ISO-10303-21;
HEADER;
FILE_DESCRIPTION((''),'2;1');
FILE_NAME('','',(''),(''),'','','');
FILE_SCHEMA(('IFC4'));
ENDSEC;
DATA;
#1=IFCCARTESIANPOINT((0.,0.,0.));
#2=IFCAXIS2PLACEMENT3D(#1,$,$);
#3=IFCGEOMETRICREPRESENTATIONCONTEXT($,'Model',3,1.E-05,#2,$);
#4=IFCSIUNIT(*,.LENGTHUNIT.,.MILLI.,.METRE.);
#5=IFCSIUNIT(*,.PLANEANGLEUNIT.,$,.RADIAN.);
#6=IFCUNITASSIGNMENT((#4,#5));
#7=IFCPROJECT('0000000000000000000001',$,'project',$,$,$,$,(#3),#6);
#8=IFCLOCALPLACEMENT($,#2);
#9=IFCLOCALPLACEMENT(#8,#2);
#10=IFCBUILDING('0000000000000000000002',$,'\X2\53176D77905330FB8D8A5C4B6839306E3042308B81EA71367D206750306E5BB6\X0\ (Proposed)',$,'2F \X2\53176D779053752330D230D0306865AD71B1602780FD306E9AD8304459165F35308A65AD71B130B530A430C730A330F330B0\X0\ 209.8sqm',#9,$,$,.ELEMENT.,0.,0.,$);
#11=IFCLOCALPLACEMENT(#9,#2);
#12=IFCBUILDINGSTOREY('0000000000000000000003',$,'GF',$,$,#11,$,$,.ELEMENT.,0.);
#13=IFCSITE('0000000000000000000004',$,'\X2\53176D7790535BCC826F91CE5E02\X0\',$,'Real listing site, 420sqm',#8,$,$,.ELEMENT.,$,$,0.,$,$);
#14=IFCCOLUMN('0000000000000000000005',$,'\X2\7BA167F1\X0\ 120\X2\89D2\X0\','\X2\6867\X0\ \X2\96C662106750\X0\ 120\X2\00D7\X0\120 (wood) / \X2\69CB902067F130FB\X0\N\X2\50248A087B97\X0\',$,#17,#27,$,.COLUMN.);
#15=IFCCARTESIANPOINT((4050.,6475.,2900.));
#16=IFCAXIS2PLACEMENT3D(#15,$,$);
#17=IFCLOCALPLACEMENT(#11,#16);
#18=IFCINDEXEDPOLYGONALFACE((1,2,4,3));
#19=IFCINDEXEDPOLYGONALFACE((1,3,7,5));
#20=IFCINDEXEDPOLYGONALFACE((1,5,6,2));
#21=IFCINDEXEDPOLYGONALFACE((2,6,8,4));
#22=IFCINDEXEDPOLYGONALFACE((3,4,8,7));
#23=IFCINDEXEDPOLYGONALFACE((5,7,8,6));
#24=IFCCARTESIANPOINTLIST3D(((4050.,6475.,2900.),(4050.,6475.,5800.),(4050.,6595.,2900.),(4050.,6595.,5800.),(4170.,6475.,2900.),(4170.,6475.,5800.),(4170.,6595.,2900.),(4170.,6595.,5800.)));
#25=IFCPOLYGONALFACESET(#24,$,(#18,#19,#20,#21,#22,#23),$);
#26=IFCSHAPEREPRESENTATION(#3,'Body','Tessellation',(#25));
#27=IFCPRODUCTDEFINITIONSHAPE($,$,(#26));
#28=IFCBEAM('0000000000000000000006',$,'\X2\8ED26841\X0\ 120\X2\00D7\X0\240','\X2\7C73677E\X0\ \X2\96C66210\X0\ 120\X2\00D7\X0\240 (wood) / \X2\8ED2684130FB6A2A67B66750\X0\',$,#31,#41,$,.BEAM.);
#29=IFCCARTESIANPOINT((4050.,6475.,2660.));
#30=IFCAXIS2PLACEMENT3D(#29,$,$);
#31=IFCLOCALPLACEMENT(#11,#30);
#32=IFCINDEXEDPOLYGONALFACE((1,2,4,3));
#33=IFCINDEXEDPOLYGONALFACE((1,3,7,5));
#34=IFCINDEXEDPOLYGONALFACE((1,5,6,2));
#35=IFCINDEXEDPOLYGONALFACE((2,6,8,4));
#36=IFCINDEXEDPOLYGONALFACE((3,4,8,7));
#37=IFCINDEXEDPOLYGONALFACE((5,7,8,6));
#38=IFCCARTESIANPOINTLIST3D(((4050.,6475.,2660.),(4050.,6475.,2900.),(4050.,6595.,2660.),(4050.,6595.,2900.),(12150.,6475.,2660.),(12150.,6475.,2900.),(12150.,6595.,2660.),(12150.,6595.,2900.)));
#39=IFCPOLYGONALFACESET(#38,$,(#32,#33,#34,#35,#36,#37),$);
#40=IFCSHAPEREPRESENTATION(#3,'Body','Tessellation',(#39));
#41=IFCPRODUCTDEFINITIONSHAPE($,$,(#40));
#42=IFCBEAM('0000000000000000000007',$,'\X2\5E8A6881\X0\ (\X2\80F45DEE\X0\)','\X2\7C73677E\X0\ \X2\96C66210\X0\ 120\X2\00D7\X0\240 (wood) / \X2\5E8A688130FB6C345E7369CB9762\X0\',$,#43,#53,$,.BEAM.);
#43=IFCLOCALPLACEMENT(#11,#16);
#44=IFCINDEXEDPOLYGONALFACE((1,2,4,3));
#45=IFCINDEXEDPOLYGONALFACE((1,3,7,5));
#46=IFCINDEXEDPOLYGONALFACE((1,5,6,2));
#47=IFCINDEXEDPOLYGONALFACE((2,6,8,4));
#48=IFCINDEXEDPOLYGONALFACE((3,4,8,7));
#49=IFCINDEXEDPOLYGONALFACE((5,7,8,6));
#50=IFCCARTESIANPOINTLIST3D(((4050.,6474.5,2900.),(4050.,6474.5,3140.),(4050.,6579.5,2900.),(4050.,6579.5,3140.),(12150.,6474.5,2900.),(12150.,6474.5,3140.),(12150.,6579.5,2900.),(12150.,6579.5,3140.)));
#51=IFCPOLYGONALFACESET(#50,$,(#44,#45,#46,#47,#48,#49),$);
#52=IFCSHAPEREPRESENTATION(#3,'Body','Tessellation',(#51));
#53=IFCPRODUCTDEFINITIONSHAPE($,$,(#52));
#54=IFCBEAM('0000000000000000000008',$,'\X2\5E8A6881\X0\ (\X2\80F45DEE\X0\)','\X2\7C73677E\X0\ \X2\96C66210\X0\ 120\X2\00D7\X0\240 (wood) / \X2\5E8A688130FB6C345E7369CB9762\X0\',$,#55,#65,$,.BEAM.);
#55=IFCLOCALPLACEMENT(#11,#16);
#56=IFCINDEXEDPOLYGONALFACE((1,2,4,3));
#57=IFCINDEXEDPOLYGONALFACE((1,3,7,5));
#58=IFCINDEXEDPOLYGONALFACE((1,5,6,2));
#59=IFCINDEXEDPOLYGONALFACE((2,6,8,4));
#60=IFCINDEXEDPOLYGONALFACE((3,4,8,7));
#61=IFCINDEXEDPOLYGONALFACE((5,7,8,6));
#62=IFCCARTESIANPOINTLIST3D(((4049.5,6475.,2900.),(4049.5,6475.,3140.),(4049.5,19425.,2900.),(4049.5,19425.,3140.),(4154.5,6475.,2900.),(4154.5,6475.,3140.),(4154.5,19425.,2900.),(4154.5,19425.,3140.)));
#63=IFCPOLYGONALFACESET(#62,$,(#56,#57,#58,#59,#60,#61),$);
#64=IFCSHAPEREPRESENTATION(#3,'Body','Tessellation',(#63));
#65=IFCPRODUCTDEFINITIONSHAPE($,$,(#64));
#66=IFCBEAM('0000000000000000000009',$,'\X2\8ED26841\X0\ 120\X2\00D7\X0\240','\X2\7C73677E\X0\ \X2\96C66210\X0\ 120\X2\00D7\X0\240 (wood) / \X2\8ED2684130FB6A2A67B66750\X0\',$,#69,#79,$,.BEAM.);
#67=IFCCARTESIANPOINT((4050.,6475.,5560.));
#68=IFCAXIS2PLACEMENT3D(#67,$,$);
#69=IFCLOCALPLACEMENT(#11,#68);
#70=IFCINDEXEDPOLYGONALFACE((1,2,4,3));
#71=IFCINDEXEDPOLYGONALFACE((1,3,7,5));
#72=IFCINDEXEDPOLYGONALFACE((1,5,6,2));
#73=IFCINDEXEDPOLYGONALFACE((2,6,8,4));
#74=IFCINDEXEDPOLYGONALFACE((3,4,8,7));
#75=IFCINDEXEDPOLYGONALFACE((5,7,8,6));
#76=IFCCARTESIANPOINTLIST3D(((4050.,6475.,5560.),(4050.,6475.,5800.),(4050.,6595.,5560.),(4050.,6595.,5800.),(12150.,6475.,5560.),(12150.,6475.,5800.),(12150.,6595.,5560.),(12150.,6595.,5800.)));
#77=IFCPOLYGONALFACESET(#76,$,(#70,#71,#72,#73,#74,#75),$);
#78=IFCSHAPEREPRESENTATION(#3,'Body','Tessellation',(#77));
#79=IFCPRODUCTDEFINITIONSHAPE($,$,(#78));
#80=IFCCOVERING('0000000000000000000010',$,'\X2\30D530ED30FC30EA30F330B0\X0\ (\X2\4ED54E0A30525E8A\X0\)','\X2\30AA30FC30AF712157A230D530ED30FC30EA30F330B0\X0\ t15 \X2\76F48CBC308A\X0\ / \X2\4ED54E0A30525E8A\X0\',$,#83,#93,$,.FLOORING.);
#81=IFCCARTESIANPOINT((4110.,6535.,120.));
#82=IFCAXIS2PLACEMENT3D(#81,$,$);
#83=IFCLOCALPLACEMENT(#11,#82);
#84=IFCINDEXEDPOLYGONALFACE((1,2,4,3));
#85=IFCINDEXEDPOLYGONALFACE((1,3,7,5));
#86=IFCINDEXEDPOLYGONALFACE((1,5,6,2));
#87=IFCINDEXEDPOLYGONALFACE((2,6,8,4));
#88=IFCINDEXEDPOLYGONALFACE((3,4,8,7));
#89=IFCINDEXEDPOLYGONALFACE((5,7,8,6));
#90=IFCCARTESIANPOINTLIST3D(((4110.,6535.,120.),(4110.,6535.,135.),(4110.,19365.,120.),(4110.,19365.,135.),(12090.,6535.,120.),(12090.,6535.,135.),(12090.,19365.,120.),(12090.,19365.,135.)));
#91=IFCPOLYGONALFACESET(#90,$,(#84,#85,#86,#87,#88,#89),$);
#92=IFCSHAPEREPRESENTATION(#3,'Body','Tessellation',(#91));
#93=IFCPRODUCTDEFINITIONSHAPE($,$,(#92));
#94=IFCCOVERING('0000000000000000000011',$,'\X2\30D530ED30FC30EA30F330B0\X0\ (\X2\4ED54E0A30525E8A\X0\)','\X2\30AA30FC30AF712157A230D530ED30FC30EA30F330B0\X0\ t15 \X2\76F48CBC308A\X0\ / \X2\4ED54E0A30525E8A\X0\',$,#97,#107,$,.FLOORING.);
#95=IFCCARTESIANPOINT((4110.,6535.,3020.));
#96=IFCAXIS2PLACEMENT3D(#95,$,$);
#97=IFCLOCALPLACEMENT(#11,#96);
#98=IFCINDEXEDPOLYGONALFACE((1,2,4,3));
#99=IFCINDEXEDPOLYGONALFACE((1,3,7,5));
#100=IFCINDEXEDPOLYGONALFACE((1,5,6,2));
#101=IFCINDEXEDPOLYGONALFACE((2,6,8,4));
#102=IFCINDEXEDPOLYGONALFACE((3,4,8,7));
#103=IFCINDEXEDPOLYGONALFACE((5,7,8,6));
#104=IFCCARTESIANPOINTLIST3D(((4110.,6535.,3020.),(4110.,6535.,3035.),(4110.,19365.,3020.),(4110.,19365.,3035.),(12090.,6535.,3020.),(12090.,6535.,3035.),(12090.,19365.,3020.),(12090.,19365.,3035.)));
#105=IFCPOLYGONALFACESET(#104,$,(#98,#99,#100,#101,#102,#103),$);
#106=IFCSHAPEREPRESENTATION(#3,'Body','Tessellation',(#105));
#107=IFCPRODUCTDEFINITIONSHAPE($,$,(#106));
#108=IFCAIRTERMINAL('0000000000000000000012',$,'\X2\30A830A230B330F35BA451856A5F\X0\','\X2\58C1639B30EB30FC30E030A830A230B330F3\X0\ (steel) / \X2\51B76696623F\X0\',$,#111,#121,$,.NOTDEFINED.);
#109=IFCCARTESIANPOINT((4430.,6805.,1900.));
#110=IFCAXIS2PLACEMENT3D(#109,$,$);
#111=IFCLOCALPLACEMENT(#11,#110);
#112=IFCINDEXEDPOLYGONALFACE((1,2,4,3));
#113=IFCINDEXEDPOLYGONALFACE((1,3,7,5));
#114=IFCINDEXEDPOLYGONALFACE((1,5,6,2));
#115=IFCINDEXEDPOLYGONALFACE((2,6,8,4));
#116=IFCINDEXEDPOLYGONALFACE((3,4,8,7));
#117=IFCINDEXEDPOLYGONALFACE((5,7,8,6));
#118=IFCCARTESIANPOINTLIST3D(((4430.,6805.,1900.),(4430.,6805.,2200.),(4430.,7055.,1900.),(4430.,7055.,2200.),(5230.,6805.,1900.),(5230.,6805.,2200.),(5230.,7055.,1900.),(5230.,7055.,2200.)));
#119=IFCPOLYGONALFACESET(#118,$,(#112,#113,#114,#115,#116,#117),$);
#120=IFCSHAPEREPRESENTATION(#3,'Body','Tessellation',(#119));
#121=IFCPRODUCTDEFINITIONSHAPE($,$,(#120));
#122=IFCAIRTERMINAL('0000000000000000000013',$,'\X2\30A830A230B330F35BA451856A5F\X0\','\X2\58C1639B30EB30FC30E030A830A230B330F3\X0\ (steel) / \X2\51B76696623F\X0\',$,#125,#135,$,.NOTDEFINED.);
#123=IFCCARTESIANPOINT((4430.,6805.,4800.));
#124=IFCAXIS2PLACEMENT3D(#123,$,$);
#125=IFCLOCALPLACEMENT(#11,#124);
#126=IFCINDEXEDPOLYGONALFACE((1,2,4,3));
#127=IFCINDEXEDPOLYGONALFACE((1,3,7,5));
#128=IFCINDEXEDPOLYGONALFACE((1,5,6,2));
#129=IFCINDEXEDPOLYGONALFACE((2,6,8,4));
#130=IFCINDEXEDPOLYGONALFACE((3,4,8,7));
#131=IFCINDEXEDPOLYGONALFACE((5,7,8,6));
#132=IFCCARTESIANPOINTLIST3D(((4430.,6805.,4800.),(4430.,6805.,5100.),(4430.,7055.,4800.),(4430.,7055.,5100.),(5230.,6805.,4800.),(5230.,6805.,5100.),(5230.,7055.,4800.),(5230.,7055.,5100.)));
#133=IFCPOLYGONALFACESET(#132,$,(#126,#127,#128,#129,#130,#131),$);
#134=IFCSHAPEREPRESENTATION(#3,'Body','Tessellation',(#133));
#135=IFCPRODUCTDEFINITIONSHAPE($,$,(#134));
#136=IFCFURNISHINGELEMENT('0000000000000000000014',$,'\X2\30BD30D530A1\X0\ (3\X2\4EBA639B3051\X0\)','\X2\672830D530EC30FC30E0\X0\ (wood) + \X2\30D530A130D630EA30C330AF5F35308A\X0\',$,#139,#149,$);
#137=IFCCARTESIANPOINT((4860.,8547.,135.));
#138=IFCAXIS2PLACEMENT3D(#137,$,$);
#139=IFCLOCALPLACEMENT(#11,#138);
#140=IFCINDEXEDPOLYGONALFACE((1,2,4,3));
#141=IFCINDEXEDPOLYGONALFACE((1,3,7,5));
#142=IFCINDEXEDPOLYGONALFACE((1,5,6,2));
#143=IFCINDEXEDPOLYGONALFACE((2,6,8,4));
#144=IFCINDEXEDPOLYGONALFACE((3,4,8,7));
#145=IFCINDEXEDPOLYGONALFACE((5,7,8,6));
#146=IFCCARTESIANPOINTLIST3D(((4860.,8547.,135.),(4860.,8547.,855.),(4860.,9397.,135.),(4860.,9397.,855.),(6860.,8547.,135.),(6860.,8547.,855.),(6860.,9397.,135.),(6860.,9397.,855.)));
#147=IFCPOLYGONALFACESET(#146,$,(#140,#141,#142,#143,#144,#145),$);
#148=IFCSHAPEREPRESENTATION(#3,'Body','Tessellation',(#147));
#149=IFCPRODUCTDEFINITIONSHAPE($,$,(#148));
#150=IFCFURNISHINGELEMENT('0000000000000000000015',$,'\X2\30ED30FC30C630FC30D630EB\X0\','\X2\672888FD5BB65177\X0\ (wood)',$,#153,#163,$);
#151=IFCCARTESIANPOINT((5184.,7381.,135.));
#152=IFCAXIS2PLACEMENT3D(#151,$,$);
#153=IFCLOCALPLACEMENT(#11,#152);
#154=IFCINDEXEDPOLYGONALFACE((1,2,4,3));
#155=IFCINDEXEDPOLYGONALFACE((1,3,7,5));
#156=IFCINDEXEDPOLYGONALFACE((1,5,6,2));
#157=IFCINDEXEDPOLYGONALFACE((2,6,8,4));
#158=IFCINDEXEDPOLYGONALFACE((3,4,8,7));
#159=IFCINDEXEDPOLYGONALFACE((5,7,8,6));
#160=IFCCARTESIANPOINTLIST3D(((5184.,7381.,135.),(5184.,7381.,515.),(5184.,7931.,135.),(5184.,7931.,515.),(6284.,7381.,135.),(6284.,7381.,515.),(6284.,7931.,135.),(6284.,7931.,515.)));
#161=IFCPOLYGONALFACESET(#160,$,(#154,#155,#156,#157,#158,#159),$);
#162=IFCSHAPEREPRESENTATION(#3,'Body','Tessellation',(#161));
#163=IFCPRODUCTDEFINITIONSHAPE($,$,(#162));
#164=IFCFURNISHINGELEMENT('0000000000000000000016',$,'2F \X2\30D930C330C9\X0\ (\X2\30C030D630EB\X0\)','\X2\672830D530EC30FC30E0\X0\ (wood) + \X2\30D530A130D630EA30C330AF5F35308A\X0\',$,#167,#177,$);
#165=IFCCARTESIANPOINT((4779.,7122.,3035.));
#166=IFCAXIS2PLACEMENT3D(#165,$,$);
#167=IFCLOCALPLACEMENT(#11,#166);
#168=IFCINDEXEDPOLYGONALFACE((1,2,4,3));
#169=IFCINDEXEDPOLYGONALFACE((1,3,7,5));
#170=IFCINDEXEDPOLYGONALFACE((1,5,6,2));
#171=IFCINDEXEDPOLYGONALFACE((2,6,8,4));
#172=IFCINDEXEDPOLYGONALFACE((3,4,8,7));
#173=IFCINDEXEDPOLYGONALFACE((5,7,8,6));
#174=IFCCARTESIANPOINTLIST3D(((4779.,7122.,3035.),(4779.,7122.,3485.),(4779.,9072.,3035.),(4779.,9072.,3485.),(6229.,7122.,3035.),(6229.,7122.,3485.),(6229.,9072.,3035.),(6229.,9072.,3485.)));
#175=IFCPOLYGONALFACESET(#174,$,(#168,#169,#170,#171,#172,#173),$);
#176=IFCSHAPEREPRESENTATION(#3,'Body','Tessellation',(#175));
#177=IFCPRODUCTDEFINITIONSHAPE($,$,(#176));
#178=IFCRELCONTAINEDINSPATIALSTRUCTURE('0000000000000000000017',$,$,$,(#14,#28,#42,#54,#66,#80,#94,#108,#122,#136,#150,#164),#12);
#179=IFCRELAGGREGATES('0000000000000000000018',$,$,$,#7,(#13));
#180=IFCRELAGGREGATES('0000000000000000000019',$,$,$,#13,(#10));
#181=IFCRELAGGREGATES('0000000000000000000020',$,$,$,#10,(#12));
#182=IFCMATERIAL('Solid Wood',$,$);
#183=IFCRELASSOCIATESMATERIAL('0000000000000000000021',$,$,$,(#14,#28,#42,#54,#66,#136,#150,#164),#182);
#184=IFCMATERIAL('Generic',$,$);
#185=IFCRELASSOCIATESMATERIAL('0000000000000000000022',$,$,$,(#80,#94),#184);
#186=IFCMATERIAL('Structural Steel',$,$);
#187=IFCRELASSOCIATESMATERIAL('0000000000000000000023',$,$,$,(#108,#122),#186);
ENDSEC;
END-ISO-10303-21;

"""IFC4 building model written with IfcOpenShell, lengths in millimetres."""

from ifc_helpers import new_model, si_unit, frame, frame_2d, origin, place, context, project, spatial, rectangle, extrude, material, element, save


model = new_model("IFC4")

# Units and contexts
model_context = context("Model", 3, precision=1e-05, world=origin())
ifc_project = project(units=[si_unit("LENGTHUNIT", "METRE", prefix="MILLI"), si_unit("PLANEANGLEUNIT", "RADIAN")], contexts=[model_context])

# Site, building, storey
site_placement = place(None, origin())
site = spatial("IfcSite", under=ifc_project, at=site_placement, Name="北海道富良野市", ObjectType="Real listing site, 420sqm", CompositionType="ELEMENT", RefElevation=0.0)
building_placement = place(site_placement, origin())
building = spatial("IfcBuilding", under=site, at=building_placement, Name="北海道・越屋根のある自然素材の家 (Proposed)", ObjectType="2F 北海道産ヒバと断熱性能の高い外張り断熱サイディング 209.8sqm", CompositionType="ELEMENT", ElevationOfRefHeight=0.0, ElevationOfTerrain=0.0)
storey_placement = place(building_placement, origin())
storey = spatial("IfcBuildingStorey", under=building, at=storey_placement, Name="GF", CompositionType="ELEMENT", Elevation=0.0)

# Column
ifc_material_1 = material(Name="Solid Wood")
column_1_placement = place(storey_placement, frame((4050.0, 6475.0, 2900.0)))
element("IfcColumn", 1, at=column_1_placement, inside=storey, material=ifc_material_1, Name="管柱 120角", Description="桧 集成材 120×120 (wood) / 構造柱・N値計算", PredefinedType="COLUMN", context=model_context, shape_type="SweptSolid", body=[
    extrude(rectangle(XDim=120.0, YDim=120.0, at=frame_2d((60.0, 60.0))), frame((4050.0, 6475.0, 2900.0)), (0.0, 0.0, 1.0), 2900.0),
])

# Beams
beam_1_placement = place(storey_placement, frame((4050.0, 6475.0, 2660.0)))
element("IfcBeam", 2, at=beam_1_placement, inside=storey, material=ifc_material_1, Name="軒桁 120×240", Description="米松 集成 120×240 (wood) / 軒桁・横架材", PredefinedType="BEAM", context=model_context, shape_type="SweptSolid", body=[
    extrude(rectangle(XDim=8100.0, YDim=120.0, at=frame_2d((4050.0, 60.0))), frame((4050.0, 6475.0, 2660.0)), (0.0, 0.0, 1.0), 240.0),
])
beam_2_placement = place(storey_placement, frame((4050.0, 6475.0, 2900.0)))
element("IfcBeam", 3, at=beam_2_placement, inside=storey, material=ifc_material_1, Name="床梁 (胴差)", Description="米松 集成 120×240 (wood) / 床梁・水平構面", PredefinedType="BEAM", context=model_context, shape_type="SweptSolid", body=[
    extrude(rectangle(XDim=8100.0, YDim=105.0, at=frame_2d((4050.0, 52.0))), frame((4050.0, 6475.0, 2900.0)), (0.0, 0.0, 1.0), 240.0),
])
beam_3_placement = place(storey_placement, frame((4050.0, 6475.0, 2900.0)))
element("IfcBeam", 4, at=beam_3_placement, inside=storey, material=ifc_material_1, Name="床梁 (胴差)", Description="米松 集成 120×240 (wood) / 床梁・水平構面", PredefinedType="BEAM", context=model_context, shape_type="SweptSolid", body=[
    extrude(rectangle(XDim=105.0, YDim=12950.0, at=frame_2d((52.0, 6475.0))), frame((4050.0, 6475.0, 2900.0)), (0.0, 0.0, 1.0), 240.0),
])
beam_4_placement = place(storey_placement, frame((4050.0, 6475.0, 5560.0)))
element("IfcBeam", 5, at=beam_4_placement, inside=storey, material=ifc_material_1, Name="軒桁 120×240", Description="米松 集成 120×240 (wood) / 軒桁・横架材", PredefinedType="BEAM", context=model_context, shape_type="SweptSolid", body=[
    extrude(rectangle(XDim=8100.0, YDim=120.0, at=frame_2d((4050.0, 60.0))), frame((4050.0, 6475.0, 5560.0)), (0.0, 0.0, 1.0), 240.0),
])

# Coverings
ifc_material_2 = material(Name="Generic")
covering_1_placement = place(storey_placement, frame((4110.0, 6535.0, 120.0)))
element("IfcCovering", 6, at=covering_1_placement, inside=storey, material=ifc_material_2, Name="フローリング (仕上げ床)", Description="オーク無垢フローリング t15 直貼り / 仕上げ床", PredefinedType="FLOORING", context=model_context, shape_type="SweptSolid", body=[
    extrude(rectangle(XDim=7980.0, YDim=12830.0, at=frame_2d((3990.0, 6415.0))), frame((4110.0, 6535.0, 120.0)), (0.0, 0.0, 1.0), 15.0),
])
covering_2_placement = place(storey_placement, frame((4110.0, 6535.0, 3020.0)))
element("IfcCovering", 7, at=covering_2_placement, inside=storey, material=ifc_material_2, Name="フローリング (仕上げ床)", Description="オーク無垢フローリング t15 直貼り / 仕上げ床", PredefinedType="FLOORING", context=model_context, shape_type="SweptSolid", body=[
    extrude(rectangle(XDim=7980.0, YDim=12830.0, at=frame_2d((3990.0, 6415.0))), frame((4110.0, 6535.0, 3020.0)), (0.0, 0.0, 1.0), 15.0),
])

# Air terminals
ifc_material_3 = material(Name="Structural Steel")
air_terminal_1_placement = place(storey_placement, frame((4430.0, 6805.0, 1900.0)))
element("IfcAirTerminal", 8, at=air_terminal_1_placement, inside=storey, material=ifc_material_3, Name="エアコン室内機", Description="壁掛ルームエアコン (steel) / 冷暖房", PredefinedType="NOTDEFINED", context=model_context, shape_type="SweptSolid", body=[
    extrude(rectangle(XDim=800.0, YDim=250.0, at=frame_2d((400.0, 125.0))), frame((4430.0, 6805.0, 1900.0)), (0.0, 0.0, 1.0), 300.0),
])
air_terminal_2_placement = place(storey_placement, frame((4430.0, 6805.0, 4800.0)))
element("IfcAirTerminal", 9, at=air_terminal_2_placement, inside=storey, material=ifc_material_3, Name="エアコン室内機", Description="壁掛ルームエアコン (steel) / 冷暖房", PredefinedType="NOTDEFINED", context=model_context, shape_type="SweptSolid", body=[
    extrude(rectangle(XDim=800.0, YDim=250.0, at=frame_2d((400.0, 125.0))), frame((4430.0, 6805.0, 4800.0)), (0.0, 0.0, 1.0), 300.0),
])

# Furnishing elements
furnishing_1_placement = place(storey_placement, frame((4860.0, 8547.0, 135.0)))
element("IfcFurnishingElement", 10, at=furnishing_1_placement, inside=storey, material=ifc_material_1, Name="ソファ (3人掛け)", Description="木フレーム (wood) + ファブリック張り", context=model_context, shape_type="SweptSolid", body=[
    extrude(rectangle(XDim=2000.0, YDim=850.0, at=frame_2d((1000.0, 425.0))), frame((4860.0, 8547.0, 135.0)), (0.0, 0.0, 1.0), 720.0),
])
furnishing_2_placement = place(storey_placement, frame((5184.0, 7381.0, 135.0)))
element("IfcFurnishingElement", 11, at=furnishing_2_placement, inside=storey, material=ifc_material_1, Name="ローテーブル", Description="木製家具 (wood)", context=model_context, shape_type="SweptSolid", body=[
    extrude(rectangle(XDim=1100.0, YDim=550.0, at=frame_2d((550.0, 275.0))), frame((5184.0, 7381.0, 135.0)), (0.0, 0.0, 1.0), 380.0),
])
furnishing_3_placement = place(storey_placement, frame((4779.0, 7122.0, 3035.0)))
element("IfcFurnishingElement", 12, at=furnishing_3_placement, inside=storey, material=ifc_material_1, Name="2F ベッド (ダブル)", Description="木フレーム (wood) + ファブリック張り", context=model_context, shape_type="SweptSolid", body=[
    extrude(rectangle(XDim=1450.0, YDim=1950.0, at=frame_2d((725.0, 975.0))), frame((4779.0, 7122.0, 3035.0)), (0.0, 0.0, 1.0), 450.0),
])

save(model, "model.ifc")
